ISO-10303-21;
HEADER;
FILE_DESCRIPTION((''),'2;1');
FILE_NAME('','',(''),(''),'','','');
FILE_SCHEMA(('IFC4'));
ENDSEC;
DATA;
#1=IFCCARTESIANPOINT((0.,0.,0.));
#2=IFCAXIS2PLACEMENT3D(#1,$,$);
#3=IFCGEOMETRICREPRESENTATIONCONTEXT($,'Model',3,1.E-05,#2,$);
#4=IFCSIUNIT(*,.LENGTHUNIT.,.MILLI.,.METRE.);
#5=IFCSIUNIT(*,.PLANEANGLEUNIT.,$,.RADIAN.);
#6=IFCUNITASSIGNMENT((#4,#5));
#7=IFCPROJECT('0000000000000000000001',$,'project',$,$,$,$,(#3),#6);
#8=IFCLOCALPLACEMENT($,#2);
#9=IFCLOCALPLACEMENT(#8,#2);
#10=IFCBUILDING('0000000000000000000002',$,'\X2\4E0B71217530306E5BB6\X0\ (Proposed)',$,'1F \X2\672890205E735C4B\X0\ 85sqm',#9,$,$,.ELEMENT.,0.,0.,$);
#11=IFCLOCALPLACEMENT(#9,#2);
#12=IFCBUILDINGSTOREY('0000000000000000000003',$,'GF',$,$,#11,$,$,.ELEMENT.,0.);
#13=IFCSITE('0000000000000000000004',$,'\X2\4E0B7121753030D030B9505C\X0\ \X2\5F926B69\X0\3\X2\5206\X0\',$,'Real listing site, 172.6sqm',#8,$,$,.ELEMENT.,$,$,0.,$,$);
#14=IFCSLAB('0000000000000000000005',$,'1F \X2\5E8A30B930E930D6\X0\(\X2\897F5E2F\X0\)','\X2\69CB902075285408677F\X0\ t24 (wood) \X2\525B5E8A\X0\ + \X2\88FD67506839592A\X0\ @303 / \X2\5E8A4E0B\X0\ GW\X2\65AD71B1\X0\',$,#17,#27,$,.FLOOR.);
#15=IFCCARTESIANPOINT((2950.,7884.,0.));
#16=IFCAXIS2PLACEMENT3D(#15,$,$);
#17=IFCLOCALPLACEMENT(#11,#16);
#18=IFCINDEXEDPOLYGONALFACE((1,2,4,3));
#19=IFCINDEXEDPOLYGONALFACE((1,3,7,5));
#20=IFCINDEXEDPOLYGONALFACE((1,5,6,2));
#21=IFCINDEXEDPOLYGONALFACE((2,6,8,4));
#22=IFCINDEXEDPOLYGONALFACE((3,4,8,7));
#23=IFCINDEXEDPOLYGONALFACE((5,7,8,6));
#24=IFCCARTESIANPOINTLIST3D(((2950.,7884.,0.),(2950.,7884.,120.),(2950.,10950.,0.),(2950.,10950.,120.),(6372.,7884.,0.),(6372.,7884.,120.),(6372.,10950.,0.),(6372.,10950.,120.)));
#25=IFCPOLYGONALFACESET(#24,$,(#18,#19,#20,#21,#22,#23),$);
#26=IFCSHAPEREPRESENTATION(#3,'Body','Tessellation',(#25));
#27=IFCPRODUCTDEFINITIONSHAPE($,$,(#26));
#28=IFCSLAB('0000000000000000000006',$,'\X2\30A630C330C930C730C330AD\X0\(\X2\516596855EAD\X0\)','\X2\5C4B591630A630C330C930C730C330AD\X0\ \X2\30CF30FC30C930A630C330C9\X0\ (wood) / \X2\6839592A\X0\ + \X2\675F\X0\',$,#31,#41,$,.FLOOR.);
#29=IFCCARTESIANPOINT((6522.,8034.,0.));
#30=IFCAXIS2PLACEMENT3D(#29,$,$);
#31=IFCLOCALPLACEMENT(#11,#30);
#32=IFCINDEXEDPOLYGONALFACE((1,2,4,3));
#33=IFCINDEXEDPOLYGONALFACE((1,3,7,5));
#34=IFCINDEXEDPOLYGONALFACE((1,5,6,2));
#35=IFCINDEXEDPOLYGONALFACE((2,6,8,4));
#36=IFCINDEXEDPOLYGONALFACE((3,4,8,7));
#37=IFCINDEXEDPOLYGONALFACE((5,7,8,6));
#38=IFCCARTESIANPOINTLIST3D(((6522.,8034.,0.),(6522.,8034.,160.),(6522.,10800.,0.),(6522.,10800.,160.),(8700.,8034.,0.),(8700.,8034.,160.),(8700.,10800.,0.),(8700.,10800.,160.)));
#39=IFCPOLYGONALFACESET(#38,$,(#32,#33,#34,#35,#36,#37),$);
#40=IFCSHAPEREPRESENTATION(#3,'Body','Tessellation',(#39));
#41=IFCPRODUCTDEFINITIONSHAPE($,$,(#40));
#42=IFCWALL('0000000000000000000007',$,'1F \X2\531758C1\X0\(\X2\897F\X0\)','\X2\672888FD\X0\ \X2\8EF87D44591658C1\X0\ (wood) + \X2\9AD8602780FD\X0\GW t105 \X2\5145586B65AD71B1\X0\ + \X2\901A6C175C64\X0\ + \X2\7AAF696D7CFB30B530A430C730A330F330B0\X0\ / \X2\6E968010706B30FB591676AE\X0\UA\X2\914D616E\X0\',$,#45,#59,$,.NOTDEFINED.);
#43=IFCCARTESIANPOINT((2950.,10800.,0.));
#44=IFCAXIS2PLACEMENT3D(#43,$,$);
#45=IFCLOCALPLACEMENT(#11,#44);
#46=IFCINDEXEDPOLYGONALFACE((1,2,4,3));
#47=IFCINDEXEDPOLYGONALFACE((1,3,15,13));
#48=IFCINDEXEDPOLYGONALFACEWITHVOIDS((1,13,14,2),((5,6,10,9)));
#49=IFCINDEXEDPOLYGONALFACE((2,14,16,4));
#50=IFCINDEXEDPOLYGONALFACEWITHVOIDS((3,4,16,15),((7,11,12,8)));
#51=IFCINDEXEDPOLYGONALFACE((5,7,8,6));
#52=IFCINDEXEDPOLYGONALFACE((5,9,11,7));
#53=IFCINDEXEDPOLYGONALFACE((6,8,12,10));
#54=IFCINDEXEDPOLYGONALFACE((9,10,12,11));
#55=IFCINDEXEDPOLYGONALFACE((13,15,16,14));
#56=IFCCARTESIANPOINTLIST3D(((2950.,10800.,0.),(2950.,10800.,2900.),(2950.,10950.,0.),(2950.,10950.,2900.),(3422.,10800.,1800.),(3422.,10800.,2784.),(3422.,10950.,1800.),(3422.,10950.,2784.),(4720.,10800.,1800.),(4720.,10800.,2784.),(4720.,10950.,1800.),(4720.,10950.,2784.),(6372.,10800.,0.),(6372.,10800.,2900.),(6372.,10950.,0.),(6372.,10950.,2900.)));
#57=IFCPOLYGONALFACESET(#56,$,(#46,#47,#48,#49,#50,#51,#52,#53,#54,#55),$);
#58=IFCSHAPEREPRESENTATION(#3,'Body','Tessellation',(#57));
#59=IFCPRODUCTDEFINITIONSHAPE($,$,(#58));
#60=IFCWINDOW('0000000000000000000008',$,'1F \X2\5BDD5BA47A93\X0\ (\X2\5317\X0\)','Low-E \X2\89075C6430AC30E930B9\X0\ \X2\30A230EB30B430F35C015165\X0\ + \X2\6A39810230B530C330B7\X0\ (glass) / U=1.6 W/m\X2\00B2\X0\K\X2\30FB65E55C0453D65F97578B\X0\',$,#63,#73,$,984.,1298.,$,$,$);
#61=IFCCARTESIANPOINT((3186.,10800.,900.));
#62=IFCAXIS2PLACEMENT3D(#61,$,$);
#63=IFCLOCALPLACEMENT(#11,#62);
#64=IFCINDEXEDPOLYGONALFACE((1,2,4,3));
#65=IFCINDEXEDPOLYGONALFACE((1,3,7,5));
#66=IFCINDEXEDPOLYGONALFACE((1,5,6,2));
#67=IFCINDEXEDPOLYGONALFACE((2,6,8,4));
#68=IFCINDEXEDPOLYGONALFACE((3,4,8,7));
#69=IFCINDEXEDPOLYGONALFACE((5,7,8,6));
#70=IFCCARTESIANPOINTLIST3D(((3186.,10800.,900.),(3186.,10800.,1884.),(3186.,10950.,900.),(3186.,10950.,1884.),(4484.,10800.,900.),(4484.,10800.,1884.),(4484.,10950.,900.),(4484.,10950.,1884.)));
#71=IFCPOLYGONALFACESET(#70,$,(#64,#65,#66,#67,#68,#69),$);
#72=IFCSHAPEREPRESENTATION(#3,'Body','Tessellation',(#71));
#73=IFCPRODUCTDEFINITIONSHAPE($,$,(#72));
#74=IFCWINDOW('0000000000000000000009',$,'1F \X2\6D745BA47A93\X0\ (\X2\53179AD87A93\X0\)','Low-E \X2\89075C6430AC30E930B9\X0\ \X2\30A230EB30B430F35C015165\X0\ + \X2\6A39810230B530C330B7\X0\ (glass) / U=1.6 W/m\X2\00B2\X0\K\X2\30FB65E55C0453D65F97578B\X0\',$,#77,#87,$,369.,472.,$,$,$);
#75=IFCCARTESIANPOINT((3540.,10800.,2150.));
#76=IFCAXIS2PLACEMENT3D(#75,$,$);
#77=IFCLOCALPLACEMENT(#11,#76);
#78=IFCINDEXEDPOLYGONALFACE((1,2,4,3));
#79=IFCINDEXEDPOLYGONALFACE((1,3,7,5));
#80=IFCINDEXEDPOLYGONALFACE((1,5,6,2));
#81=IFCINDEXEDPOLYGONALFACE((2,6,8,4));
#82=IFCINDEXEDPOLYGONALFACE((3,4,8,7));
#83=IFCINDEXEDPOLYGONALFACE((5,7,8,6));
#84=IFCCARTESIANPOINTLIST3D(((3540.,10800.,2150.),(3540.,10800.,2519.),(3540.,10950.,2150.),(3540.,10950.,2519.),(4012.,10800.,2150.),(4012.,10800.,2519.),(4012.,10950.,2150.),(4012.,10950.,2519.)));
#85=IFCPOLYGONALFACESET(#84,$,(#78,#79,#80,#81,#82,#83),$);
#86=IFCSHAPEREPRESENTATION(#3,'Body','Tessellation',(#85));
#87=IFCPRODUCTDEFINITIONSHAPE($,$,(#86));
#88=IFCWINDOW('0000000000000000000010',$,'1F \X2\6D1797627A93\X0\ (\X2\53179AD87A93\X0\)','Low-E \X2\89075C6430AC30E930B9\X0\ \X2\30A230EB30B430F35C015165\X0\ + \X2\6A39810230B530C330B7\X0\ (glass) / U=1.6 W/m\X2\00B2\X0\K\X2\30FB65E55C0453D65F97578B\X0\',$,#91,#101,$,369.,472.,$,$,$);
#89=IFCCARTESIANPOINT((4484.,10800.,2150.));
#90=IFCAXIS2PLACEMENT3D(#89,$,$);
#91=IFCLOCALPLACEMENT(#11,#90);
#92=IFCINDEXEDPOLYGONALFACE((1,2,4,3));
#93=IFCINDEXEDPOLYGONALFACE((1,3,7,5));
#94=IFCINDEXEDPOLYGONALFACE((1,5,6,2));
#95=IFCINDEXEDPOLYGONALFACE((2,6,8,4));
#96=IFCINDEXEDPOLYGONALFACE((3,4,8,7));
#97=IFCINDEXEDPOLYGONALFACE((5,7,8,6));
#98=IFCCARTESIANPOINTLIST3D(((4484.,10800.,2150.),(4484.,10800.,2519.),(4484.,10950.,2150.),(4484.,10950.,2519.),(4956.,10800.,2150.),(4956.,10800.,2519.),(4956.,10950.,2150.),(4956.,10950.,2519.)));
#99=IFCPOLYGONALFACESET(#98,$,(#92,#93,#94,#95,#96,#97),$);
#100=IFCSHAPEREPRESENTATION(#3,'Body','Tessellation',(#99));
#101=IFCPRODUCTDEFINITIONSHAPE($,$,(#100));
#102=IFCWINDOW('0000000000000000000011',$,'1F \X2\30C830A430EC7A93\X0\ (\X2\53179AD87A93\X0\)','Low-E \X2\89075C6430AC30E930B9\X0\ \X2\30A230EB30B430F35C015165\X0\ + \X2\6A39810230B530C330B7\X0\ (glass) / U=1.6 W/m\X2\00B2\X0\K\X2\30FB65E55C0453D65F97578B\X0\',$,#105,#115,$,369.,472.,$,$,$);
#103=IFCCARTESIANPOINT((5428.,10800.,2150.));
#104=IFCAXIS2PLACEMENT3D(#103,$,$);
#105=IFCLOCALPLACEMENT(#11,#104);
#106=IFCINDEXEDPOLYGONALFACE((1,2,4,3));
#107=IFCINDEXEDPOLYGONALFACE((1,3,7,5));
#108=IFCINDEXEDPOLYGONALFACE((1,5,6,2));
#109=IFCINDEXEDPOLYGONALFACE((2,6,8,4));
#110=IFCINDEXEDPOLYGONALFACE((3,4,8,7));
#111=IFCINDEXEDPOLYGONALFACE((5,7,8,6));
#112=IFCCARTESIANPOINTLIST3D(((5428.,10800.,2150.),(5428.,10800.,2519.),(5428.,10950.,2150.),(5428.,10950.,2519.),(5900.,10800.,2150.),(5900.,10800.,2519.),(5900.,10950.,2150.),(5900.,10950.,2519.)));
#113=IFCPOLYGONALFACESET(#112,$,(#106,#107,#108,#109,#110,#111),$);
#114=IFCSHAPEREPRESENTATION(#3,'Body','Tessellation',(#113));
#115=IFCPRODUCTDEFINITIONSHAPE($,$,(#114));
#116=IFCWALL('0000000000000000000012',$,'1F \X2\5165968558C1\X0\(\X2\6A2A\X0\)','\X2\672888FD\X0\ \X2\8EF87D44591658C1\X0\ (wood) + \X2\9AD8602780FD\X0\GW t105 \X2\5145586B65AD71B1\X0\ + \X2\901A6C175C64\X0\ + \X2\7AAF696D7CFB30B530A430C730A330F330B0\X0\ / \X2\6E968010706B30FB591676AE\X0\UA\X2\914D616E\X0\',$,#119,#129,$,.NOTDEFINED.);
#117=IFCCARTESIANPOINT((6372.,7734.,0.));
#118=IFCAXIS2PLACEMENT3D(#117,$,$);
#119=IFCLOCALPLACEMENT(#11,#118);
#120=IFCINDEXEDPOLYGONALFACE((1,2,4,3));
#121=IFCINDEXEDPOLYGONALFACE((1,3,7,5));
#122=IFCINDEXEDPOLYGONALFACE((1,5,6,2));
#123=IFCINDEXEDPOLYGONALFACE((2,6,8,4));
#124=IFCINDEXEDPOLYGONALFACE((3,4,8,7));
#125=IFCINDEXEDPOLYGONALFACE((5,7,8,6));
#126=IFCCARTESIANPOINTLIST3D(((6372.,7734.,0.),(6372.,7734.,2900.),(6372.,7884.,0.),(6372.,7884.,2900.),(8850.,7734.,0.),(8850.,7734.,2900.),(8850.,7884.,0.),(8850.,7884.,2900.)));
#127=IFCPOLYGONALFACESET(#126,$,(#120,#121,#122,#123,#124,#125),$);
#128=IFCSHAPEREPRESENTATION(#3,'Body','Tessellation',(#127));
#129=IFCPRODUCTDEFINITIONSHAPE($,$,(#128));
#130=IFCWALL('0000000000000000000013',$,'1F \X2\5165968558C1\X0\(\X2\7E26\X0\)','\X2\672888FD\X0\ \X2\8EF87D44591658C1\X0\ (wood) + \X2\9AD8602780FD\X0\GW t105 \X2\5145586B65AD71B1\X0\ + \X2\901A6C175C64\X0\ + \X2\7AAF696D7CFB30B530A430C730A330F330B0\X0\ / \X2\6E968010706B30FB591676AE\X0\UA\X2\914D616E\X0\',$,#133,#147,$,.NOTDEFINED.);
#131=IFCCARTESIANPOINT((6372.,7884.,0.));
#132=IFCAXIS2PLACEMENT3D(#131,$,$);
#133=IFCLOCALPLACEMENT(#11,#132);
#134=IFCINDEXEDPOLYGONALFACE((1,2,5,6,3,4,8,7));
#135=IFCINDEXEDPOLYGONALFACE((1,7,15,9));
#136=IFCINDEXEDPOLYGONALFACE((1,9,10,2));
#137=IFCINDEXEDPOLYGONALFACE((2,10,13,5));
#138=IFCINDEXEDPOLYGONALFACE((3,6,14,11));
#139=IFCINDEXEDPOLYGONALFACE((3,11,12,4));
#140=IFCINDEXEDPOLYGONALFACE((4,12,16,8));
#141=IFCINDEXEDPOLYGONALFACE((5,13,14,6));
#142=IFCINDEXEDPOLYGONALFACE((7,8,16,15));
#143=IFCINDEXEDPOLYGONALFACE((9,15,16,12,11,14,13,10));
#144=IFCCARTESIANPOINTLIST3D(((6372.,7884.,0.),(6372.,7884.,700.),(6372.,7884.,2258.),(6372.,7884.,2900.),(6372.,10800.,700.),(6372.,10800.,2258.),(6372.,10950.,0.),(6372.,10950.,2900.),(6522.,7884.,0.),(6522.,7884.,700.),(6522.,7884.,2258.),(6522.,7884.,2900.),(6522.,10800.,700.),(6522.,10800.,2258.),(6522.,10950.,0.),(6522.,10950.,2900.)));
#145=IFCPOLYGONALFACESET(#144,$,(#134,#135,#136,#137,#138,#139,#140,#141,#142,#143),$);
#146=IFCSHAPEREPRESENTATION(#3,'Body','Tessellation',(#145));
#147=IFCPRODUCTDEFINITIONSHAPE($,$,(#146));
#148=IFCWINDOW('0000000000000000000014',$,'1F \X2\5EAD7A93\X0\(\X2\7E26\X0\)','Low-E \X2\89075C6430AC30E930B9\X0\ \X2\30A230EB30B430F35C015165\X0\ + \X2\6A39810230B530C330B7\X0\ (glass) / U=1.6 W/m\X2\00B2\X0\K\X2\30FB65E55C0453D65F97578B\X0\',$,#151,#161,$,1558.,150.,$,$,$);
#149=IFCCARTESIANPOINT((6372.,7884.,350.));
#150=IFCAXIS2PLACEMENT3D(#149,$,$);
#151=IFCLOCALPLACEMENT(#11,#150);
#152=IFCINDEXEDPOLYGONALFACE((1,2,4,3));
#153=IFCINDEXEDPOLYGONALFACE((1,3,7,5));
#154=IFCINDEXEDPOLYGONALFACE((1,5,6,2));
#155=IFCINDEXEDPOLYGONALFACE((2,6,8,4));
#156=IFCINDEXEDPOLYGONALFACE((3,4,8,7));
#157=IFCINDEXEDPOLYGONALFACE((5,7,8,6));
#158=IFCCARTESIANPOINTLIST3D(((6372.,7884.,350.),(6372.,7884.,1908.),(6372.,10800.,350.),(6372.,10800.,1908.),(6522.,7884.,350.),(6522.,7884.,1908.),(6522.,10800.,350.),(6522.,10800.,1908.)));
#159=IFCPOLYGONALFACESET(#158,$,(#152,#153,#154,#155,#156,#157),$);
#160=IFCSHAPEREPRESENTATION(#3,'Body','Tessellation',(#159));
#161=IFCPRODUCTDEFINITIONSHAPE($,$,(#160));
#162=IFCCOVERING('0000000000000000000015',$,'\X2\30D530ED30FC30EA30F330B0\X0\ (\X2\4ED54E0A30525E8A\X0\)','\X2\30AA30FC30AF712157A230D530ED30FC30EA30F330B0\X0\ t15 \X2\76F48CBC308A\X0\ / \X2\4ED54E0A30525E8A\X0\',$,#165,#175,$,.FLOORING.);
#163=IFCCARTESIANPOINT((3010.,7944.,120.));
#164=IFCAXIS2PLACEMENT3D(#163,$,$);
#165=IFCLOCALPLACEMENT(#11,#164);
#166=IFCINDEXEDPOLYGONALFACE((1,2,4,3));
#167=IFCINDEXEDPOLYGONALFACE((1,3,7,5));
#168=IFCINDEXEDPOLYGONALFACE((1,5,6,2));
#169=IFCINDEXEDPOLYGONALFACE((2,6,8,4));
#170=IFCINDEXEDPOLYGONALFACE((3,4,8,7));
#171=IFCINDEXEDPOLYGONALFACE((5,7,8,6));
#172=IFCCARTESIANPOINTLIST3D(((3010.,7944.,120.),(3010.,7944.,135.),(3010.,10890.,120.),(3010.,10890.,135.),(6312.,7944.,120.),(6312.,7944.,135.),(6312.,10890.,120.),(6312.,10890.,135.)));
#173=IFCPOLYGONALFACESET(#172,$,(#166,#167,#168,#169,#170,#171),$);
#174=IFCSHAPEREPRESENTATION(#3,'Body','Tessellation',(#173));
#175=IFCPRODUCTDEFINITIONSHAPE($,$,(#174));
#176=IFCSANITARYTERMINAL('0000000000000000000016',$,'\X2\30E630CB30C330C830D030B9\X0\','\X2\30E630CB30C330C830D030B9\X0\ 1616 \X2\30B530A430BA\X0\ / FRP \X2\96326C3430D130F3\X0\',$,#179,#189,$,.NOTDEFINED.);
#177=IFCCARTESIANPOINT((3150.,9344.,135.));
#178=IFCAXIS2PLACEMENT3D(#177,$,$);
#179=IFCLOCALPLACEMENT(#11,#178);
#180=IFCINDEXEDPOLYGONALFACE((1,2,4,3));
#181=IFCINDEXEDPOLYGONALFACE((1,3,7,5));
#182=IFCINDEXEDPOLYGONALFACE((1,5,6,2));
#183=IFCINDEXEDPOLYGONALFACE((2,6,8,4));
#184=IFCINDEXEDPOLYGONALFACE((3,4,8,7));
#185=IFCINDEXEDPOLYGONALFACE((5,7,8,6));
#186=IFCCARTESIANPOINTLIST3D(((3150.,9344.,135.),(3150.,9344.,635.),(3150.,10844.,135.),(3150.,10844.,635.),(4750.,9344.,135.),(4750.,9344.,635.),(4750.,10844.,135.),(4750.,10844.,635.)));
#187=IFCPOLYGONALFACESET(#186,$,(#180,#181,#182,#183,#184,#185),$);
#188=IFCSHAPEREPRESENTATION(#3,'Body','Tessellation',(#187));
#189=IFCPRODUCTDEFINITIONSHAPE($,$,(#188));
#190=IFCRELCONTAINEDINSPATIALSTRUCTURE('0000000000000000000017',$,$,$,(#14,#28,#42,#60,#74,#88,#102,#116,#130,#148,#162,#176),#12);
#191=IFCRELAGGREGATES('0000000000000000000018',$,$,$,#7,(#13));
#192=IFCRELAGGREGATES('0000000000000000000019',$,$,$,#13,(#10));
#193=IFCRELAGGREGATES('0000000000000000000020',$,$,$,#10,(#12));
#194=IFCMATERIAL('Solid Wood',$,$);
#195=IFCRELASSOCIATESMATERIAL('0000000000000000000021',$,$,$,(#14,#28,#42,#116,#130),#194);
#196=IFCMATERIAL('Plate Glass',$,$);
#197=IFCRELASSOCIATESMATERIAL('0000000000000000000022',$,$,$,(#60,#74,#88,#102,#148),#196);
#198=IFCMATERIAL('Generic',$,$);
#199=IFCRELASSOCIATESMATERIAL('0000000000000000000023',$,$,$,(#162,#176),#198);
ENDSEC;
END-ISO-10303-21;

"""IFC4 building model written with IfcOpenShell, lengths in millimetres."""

from ifc_helpers import new_model, si_unit, frame, frame_2d, origin, place, context, project, spatial, rectangle, extrude, material, element, fill, save


model = new_model("IFC4")

# Units and contexts
model_context = context("Model", 3, precision=1e-05, world=origin())
ifc_project = project(units=[si_unit("LENGTHUNIT", "METRE", prefix="MILLI"), si_unit("PLANEANGLEUNIT", "RADIAN")], contexts=[model_context])

# Site, building, storey
site_placement = place(None, origin())
site = spatial("IfcSite", under=ifc_project, at=site_placement, Name="下無田バス停 徒歩3分", ObjectType="Real listing site, 172.6sqm", CompositionType="ELEMENT", RefElevation=0.0)
building_placement = place(site_placement, origin())
building = spatial("IfcBuilding", under=site, at=building_placement, Name="下無田の家 (Proposed)", ObjectType="1F 木造平屋 85sqm", CompositionType="ELEMENT", ElevationOfRefHeight=0.0, ElevationOfTerrain=0.0)
storey_placement = place(building_placement, origin())
storey = spatial("IfcBuildingStorey", under=building, at=storey_placement, Name="GF", CompositionType="ELEMENT", Elevation=0.0)

# Slabs
ifc_material_1 = material(Name="Solid Wood")
slab_1_placement = place(storey_placement, frame((2950.0, 7884.0, 0.0)))
element("IfcSlab", 1, at=slab_1_placement, inside=storey, material=ifc_material_1, Name="1F 床スラブ(西帯)", Description="構造用合板 t24 (wood) 剛床 + 製材根太 @303 / 床下 GW断熱", PredefinedType="FLOOR", context=model_context, shape_type="SweptSolid", body=[
    extrude(rectangle(XDim=3422.0, YDim=3066.0, at=frame_2d((1711.0, 1533.0))), frame((2950.0, 7884.0, 0.0)), (0.0, 0.0, 1.0), 120.0),
])
slab_2_placement = place(storey_placement, frame((6522.0, 8034.0, 0.0)))
element("IfcSlab", 2, at=slab_2_placement, inside=storey, material=ifc_material_1, Name="ウッドデッキ(入隅庭)", Description="屋外ウッドデッキ ハードウッド (wood) / 根太 + 束", PredefinedType="FLOOR", context=model_context, shape_type="SweptSolid", body=[
    extrude(rectangle(XDim=2178.0, YDim=2766.0, at=frame_2d((1089.0, 1383.0))), frame((6522.0, 8034.0, 0.0)), (0.0, 0.0, 1.0), 160.0),
])

# Wall, openings, windows
wall_1_placement = place(storey_placement, frame((2950.0, 10800.0, 0.0)))
wall_1 = element("IfcWall", 3, at=wall_1_placement, inside=storey, material=ifc_material_1, Name="1F 北壁(西)", Description="木製 軸組外壁 (wood) + 高性能GW t105 充填断熱 + 通気層 + 窯業系サイディング / 準耐火・外皮UA配慮", PredefinedType="NOTDEFINED", context=model_context, shape_type="SweptSolid", body=[
    extrude(rectangle(XDim=3422.0, YDim=150.0, at=frame_2d((1711.0, 75.0))), frame((2950.0, 10800.0, 0.0)), (0.0, 0.0, 1.0), 2900.0),
])
opening_1_placement = place(storey_placement, frame((3186.0, 10800.0, 900.0)))
opening_1 = element("IfcOpeningElement", 4, at=opening_1_placement, cuts=wall_1, PredefinedType="NOTDEFINED", context=model_context, shape_type="SweptSolid", body=[
    extrude(rectangle(XDim=1298.0, YDim=150.0, at=frame_2d((649.0, 75.0))), frame((3186.0, 10800.0, 900.0)), (0.0, 0.0, 1.0), 984.0),
])
opening_2_placement = place(storey_placement, frame((3540.0, 10800.0, 2150.0)))
opening_2 = element("IfcOpeningElement", 5, at=opening_2_placement, cuts=wall_1, PredefinedType="NOTDEFINED", context=model_context, shape_type="SweptSolid", body=[
    extrude(rectangle(XDim=472.0, YDim=150.0, at=frame_2d((236.0, 75.0))), frame((3540.0, 10800.0, 2150.0)), (0.0, 0.0, 1.0), 369.0),
])
opening_3_placement = place(storey_placement, frame((4484.0, 10800.0, 2150.0)))
opening_3 = element("IfcOpeningElement", 6, at=opening_3_placement, cuts=wall_1, PredefinedType="NOTDEFINED", context=model_context, shape_type="SweptSolid", body=[
    extrude(rectangle(XDim=472.0, YDim=150.0, at=frame_2d((236.0, 75.0))), frame((4484.0, 10800.0, 2150.0)), (0.0, 0.0, 1.0), 369.0),
])
opening_4_placement = place(storey_placement, frame((5428.0, 10800.0, 2150.0)))
opening_4 = element("IfcOpeningElement", 7, at=opening_4_placement, cuts=wall_1, PredefinedType="NOTDEFINED", context=model_context, shape_type="SweptSolid", body=[
    extrude(rectangle(XDim=472.0, YDim=150.0, at=frame_2d((236.0, 75.0))), frame((5428.0, 10800.0, 2150.0)), (0.0, 0.0, 1.0), 369.0),
])
ifc_material_2 = material(Name="Plate Glass")
window_1_placement = place(storey_placement, frame((3186.0, 10800.0, 900.0)))
window_1 = element("IfcWindow", 8, at=window_1_placement, inside=storey, material=ifc_material_2, Name="1F 寝室窓 (北)", Description="Low-E 複層ガラス アルゴン封入 + 樹脂サッシ (glass) / U=1.6 W/m²K・日射取得型", OverallHeight=984.0, OverallWidth=1298.0, context=model_context, shape_type="SweptSolid", body=[
    extrude(rectangle(XDim=1298.0, YDim=150.0, at=frame_2d((649.0, 75.0))), frame((3186.0, 10800.0, 900.0)), (0.0, 0.0, 1.0), 984.0),
])
fill(opening_1, window_1)
window_2_placement = place(storey_placement, frame((3540.0, 10800.0, 2150.0)))
window_2 = element("IfcWindow", 9, at=window_2_placement, inside=storey, material=ifc_material_2, Name="1F 浴室窓 (北高窓)", Description="Low-E 複層ガラス アルゴン封入 + 樹脂サッシ (glass) / U=1.6 W/m²K・日射取得型", OverallHeight=369.0, OverallWidth=472.0, context=model_context, shape_type="SweptSolid", body=[
    extrude(rectangle(XDim=472.0, YDim=150.0, at=frame_2d((236.0, 75.0))), frame((3540.0, 10800.0, 2150.0)), (0.0, 0.0, 1.0), 369.0),
])
fill(opening_2, window_2)
window_3_placement = place(storey_placement, frame((4484.0, 10800.0, 2150.0)))
window_3 = element("IfcWindow", 10, at=window_3_placement, inside=storey, material=ifc_material_2, Name="1F 洗面窓 (北高窓)", Description="Low-E 複層ガラス アルゴン封入 + 樹脂サッシ (glass) / U=1.6 W/m²K・日射取得型", OverallHeight=369.0, OverallWidth=472.0, context=model_context, shape_type="SweptSolid", body=[
    extrude(rectangle(XDim=472.0, YDim=150.0, at=frame_2d((236.0, 75.0))), frame((4484.0, 10800.0, 2150.0)), (0.0, 0.0, 1.0), 369.0),
])
fill(opening_3, window_3)
window_4_placement = place(storey_placement, frame((5428.0, 10800.0, 2150.0)))
window_4 = element("IfcWindow", 11, at=window_4_placement, inside=storey, material=ifc_material_2, Name="1F トイレ窓 (北高窓)", Description="Low-E 複層ガラス アルゴン封入 + 樹脂サッシ (glass) / U=1.6 W/m²K・日射取得型", OverallHeight=369.0, OverallWidth=472.0, context=model_context, shape_type="SweptSolid", body=[
    extrude(rectangle(XDim=472.0, YDim=150.0, at=frame_2d((236.0, 75.0))), frame((5428.0, 10800.0, 2150.0)), (0.0, 0.0, 1.0), 369.0),
])
fill(opening_4, window_4)

# Wall
wall_2_placement = place(storey_placement, frame((6372.0, 7734.0, 0.0)))
element("IfcWall", 12, at=wall_2_placement, inside=storey, material=ifc_material_1, Name="1F 入隅壁(横)", Description="木製 軸組外壁 (wood) + 高性能GW t105 充填断熱 + 通気層 + 窯業系サイディング / 準耐火・外皮UA配慮", PredefinedType="NOTDEFINED", context=model_context, shape_type="SweptSolid", body=[
    extrude(rectangle(XDim=2478.0, YDim=150.0, at=frame_2d((1239.0, 75.0))), frame((6372.0, 7734.0, 0.0)), (0.0, 0.0, 1.0), 2900.0),
])

# Wall, opening, window
wall_3_placement = place(storey_placement, frame((6372.0, 7884.0, 0.0)))
wall_3 = element("IfcWall", 13, at=wall_3_placement, inside=storey, material=ifc_material_1, Name="1F 入隅壁(縦)", Description="木製 軸組外壁 (wood) + 高性能GW t105 充填断熱 + 通気層 + 窯業系サイディング / 準耐火・外皮UA配慮", PredefinedType="NOTDEFINED", context=model_context, shape_type="SweptSolid", body=[
    extrude(rectangle(XDim=150.0, YDim=3066.0, at=frame_2d((75.0, 1533.0))), frame((6372.0, 7884.0, 0.0)), (0.0, 0.0, 1.0), 2900.0),
])
opening_5_placement = place(storey_placement, frame((6372.0, 7884.0, 350.0)))
opening_5 = element("IfcOpeningElement", 14, at=opening_5_placement, cuts=wall_3, PredefinedType="NOTDEFINED", context=model_context, shape_type="SweptSolid", body=[
    extrude(rectangle(XDim=150.0, YDim=2916.0, at=frame_2d((75.0, 1458.0))), frame((6372.0, 7884.0, 350.0)), (0.0, 0.0, 1.0), 1558.0),
])
window_5_placement = place(storey_placement, frame((6372.0, 7884.0, 350.0)))
window_5 = element("IfcWindow", 15, at=window_5_placement, inside=storey, material=ifc_material_2, Name="1F 庭窓(縦)", Description="Low-E 複層ガラス アルゴン封入 + 樹脂サッシ (glass) / U=1.6 W/m²K・日射取得型", OverallHeight=1558.0, OverallWidth=150.0, context=model_context, shape_type="SweptSolid", body=[
    extrude(rectangle(XDim=150.0, YDim=2916.0, at=frame_2d((75.0, 1458.0))), frame((6372.0, 7884.0, 350.0)), (0.0, 0.0, 1.0), 1558.0),
])
fill(opening_5, window_5)

# Covering
ifc_material_3 = material(Name="Generic")
covering_placement = place(storey_placement, frame((3010.0, 7944.0, 120.0)))
element("IfcCovering", 16, at=covering_placement, inside=storey, material=ifc_material_3, Name="フローリング (仕上げ床)", Description="オーク無垢フローリング t15 直貼り / 仕上げ床", PredefinedType="FLOORING", context=model_context, shape_type="SweptSolid", body=[
    extrude(rectangle(XDim=3302.0, YDim=2946.0, at=frame_2d((1651.0, 1473.0))), frame((3010.0, 7944.0, 120.0)), (0.0, 0.0, 1.0), 15.0),
])

# Sanitary terminal
sanitary_terminal_1_placement = place(storey_placement, frame((3150.0, 9344.0, 135.0)))
element("IfcSanitaryTerminal", 17, at=sanitary_terminal_1_placement, inside=storey, material=ifc_material_3, Name="ユニットバス", Description="ユニットバス 1616 サイズ / FRP 防水パン", PredefinedType="NOTDEFINED", context=model_context, shape_type="SweptSolid", body=[
    extrude(rectangle(XDim=1600.0, YDim=1500.0, at=frame_2d((800.0, 750.0))), frame((3150.0, 9344.0, 135.0)), (0.0, 0.0, 1.0), 500.0),
])

save(model, "model.ifc")
